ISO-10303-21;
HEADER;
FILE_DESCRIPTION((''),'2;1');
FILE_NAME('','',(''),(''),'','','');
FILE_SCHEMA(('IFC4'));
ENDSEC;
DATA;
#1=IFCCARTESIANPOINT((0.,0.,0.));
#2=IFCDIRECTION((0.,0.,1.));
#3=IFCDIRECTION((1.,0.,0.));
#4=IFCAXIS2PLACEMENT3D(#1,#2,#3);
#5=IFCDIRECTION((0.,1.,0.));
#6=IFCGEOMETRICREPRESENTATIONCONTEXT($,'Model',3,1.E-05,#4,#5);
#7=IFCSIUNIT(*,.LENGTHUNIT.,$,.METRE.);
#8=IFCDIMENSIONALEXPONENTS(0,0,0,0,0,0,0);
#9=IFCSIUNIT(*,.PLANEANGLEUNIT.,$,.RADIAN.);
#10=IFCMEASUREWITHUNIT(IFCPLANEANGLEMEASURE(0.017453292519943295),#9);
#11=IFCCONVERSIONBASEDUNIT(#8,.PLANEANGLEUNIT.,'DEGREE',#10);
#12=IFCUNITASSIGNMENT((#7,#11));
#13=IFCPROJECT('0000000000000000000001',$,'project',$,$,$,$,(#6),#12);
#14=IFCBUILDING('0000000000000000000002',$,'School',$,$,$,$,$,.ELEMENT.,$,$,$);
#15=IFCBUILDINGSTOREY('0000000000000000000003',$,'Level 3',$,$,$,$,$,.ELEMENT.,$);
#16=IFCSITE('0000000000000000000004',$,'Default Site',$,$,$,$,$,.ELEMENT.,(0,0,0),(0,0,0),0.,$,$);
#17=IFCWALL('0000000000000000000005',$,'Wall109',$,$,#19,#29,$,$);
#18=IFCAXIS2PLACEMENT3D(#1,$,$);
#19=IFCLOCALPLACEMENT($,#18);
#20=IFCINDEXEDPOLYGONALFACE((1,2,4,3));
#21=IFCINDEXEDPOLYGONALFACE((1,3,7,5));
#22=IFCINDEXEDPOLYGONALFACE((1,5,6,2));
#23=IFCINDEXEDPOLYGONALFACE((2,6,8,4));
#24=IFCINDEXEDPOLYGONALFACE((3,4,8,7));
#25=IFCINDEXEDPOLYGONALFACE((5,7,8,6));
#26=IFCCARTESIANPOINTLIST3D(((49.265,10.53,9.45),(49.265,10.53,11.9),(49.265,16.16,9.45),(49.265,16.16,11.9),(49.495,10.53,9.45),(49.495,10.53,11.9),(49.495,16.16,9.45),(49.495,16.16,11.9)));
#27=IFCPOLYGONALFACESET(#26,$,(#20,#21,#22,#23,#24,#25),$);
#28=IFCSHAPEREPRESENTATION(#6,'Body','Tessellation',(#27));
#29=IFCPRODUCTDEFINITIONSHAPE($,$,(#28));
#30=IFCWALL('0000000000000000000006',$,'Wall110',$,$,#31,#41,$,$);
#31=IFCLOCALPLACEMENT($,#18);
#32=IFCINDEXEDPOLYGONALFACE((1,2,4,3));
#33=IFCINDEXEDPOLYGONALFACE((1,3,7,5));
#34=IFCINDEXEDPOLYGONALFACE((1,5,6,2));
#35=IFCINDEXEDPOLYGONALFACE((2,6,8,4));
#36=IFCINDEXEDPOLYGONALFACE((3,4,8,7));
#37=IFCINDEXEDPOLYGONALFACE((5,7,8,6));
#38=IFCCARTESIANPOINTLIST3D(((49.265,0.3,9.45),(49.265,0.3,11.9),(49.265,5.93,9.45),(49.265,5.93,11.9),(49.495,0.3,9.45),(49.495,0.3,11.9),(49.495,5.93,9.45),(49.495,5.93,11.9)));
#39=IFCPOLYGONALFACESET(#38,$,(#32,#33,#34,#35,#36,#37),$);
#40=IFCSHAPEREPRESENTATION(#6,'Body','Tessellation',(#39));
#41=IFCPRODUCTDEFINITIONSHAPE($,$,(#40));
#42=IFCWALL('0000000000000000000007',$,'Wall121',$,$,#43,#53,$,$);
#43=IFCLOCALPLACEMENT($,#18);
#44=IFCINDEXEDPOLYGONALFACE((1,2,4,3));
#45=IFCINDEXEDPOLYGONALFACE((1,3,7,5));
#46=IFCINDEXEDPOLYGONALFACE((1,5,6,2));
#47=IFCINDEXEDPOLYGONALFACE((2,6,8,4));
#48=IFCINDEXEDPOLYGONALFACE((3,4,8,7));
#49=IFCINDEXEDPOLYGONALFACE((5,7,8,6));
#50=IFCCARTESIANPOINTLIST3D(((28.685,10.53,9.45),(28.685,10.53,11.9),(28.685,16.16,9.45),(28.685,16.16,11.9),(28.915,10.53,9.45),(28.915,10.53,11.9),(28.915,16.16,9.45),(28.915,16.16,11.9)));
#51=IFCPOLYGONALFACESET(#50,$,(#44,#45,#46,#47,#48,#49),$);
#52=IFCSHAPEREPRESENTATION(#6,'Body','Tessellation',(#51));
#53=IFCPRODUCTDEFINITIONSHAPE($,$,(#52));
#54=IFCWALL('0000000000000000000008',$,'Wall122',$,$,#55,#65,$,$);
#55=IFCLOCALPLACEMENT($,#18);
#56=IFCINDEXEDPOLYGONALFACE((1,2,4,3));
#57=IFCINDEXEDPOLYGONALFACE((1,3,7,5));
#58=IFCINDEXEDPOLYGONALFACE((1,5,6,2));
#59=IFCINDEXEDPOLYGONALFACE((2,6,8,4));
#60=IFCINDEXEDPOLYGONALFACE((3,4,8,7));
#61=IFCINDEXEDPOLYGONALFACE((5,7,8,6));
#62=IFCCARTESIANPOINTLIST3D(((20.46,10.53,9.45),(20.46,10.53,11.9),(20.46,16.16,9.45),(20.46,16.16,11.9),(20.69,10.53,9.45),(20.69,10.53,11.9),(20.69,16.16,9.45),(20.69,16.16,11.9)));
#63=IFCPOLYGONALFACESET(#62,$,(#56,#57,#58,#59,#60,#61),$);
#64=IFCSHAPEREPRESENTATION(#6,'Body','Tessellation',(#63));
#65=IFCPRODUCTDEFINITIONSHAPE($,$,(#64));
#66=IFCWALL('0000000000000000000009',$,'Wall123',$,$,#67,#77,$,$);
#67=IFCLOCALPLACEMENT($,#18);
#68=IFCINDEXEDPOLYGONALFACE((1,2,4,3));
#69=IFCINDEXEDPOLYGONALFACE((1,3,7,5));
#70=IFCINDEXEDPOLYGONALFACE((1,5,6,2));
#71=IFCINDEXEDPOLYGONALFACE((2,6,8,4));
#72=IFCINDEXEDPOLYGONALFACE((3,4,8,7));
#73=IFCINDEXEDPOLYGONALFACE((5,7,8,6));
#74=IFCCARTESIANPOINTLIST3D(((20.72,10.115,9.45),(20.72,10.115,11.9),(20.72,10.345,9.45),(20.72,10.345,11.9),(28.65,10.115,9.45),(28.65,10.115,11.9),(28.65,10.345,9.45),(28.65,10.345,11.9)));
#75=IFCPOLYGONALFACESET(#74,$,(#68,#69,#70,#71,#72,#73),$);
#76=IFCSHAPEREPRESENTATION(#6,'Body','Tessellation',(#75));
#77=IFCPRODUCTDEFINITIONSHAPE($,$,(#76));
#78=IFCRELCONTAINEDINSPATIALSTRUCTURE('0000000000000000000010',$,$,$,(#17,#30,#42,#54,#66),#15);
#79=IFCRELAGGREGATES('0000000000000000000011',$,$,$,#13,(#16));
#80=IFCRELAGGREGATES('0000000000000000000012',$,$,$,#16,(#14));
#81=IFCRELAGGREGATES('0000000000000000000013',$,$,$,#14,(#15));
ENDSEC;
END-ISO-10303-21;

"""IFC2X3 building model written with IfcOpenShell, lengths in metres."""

from ifc_helpers import new_model, entity, si_unit, converted_unit, direction, frame, frame_2d, origin_with_axes, place, context, project, spatial, rectangle, extrude, element, save


model = new_model("IFC2X3")

# Units and contexts
model_context = context("Model", 3, precision=1e-05, world=origin_with_axes(), true_north=direction((0.0, 1.0, 0.0)))
ifc_project = project(units=[si_unit("LENGTHUNIT", "METRE"), converted_unit("PLANEANGLEUNIT", "DEGREE", entity("IfcPlaneAngleMeasure", 0.017453292519943295), si_unit("PLANEANGLEUNIT", "RADIAN"), dimensions=[0, 0, 0, 0, 0, 0, 0])], contexts=[model_context])

# Site, building, storey
site = spatial("IfcSite", under=ifc_project, Name="Default Site", CompositionType="ELEMENT", RefLatitude=(0, 0, 0), RefLongitude=(0, 0, 0), RefElevation=0.0)
building = spatial("IfcBuilding", under=site, Name="School", CompositionType="ELEMENT")
storey = spatial("IfcBuildingStorey", under=building, Name="Level 3", CompositionType="ELEMENT")

# Shared definitions
placement = place(None, origin_with_axes())

# Walls
element("IfcWall", 1, at=placement, inside=storey, Name="Wall109", context=model_context, shape_type="SweptSolid", body=[
    extrude(rectangle(XDim=5.63, YDim=0.23, at=frame_2d((0.0, 0.0), x_axis=(0.0, 1.0, 0.0))), frame((49.38, 13.345, 9.45), z_axis=(0.0, 0.0, 1.0), x_axis=(1.0, 0.0, 0.0)), (0.0, 0.0, 1.0), 2.45),
])
element("IfcWall", 2, at=placement, inside=storey, Name="Wall110", context=model_context, shape_type="SweptSolid", body=[
    extrude(rectangle(XDim=5.63, YDim=0.23, at=frame_2d((0.0, 0.0), x_axis=(0.0, 1.0, 0.0))), frame((49.38, 3.115, 9.45), z_axis=(0.0, 0.0, 1.0), x_axis=(1.0, 0.0, 0.0)), (0.0, 0.0, 1.0), 2.45),
])
element("IfcWall", 3, at=placement, inside=storey, Name="Wall121", context=model_context, shape_type="SweptSolid", body=[
    extrude(rectangle(XDim=5.63, YDim=0.23, at=frame_2d((0.0, 0.0), x_axis=(0.0, 1.0, 0.0))), frame((28.8, 13.345, 9.45), z_axis=(0.0, 0.0, 1.0), x_axis=(1.0, 0.0, 0.0)), (0.0, 0.0, 1.0), 2.45),
])
element("IfcWall", 4, at=placement, inside=storey, Name="Wall122", context=model_context, shape_type="SweptSolid", body=[
    extrude(rectangle(XDim=5.63, YDim=0.23, at=frame_2d((0.0, 0.0), x_axis=(0.0, 1.0, 0.0))), frame((20.575, 13.345, 9.45), z_axis=(0.0, 0.0, 1.0), x_axis=(1.0, 0.0, 0.0)), (0.0, 0.0, 1.0), 2.45),
])
element("IfcWall", 5, at=placement, inside=storey, Name="Wall123", context=model_context, shape_type="SweptSolid", body=[
    extrude(rectangle(XDim=7.93, YDim=0.23, at=frame_2d((0.0, 0.0), x_axis=(1.0, 0.0, 0.0))), frame((24.685, 10.23, 9.45), z_axis=(0.0, 0.0, 1.0), x_axis=(1.0, 0.0, 0.0)), (0.0, 0.0, 1.0), 2.45),
])

save(model, "model.ifc")
